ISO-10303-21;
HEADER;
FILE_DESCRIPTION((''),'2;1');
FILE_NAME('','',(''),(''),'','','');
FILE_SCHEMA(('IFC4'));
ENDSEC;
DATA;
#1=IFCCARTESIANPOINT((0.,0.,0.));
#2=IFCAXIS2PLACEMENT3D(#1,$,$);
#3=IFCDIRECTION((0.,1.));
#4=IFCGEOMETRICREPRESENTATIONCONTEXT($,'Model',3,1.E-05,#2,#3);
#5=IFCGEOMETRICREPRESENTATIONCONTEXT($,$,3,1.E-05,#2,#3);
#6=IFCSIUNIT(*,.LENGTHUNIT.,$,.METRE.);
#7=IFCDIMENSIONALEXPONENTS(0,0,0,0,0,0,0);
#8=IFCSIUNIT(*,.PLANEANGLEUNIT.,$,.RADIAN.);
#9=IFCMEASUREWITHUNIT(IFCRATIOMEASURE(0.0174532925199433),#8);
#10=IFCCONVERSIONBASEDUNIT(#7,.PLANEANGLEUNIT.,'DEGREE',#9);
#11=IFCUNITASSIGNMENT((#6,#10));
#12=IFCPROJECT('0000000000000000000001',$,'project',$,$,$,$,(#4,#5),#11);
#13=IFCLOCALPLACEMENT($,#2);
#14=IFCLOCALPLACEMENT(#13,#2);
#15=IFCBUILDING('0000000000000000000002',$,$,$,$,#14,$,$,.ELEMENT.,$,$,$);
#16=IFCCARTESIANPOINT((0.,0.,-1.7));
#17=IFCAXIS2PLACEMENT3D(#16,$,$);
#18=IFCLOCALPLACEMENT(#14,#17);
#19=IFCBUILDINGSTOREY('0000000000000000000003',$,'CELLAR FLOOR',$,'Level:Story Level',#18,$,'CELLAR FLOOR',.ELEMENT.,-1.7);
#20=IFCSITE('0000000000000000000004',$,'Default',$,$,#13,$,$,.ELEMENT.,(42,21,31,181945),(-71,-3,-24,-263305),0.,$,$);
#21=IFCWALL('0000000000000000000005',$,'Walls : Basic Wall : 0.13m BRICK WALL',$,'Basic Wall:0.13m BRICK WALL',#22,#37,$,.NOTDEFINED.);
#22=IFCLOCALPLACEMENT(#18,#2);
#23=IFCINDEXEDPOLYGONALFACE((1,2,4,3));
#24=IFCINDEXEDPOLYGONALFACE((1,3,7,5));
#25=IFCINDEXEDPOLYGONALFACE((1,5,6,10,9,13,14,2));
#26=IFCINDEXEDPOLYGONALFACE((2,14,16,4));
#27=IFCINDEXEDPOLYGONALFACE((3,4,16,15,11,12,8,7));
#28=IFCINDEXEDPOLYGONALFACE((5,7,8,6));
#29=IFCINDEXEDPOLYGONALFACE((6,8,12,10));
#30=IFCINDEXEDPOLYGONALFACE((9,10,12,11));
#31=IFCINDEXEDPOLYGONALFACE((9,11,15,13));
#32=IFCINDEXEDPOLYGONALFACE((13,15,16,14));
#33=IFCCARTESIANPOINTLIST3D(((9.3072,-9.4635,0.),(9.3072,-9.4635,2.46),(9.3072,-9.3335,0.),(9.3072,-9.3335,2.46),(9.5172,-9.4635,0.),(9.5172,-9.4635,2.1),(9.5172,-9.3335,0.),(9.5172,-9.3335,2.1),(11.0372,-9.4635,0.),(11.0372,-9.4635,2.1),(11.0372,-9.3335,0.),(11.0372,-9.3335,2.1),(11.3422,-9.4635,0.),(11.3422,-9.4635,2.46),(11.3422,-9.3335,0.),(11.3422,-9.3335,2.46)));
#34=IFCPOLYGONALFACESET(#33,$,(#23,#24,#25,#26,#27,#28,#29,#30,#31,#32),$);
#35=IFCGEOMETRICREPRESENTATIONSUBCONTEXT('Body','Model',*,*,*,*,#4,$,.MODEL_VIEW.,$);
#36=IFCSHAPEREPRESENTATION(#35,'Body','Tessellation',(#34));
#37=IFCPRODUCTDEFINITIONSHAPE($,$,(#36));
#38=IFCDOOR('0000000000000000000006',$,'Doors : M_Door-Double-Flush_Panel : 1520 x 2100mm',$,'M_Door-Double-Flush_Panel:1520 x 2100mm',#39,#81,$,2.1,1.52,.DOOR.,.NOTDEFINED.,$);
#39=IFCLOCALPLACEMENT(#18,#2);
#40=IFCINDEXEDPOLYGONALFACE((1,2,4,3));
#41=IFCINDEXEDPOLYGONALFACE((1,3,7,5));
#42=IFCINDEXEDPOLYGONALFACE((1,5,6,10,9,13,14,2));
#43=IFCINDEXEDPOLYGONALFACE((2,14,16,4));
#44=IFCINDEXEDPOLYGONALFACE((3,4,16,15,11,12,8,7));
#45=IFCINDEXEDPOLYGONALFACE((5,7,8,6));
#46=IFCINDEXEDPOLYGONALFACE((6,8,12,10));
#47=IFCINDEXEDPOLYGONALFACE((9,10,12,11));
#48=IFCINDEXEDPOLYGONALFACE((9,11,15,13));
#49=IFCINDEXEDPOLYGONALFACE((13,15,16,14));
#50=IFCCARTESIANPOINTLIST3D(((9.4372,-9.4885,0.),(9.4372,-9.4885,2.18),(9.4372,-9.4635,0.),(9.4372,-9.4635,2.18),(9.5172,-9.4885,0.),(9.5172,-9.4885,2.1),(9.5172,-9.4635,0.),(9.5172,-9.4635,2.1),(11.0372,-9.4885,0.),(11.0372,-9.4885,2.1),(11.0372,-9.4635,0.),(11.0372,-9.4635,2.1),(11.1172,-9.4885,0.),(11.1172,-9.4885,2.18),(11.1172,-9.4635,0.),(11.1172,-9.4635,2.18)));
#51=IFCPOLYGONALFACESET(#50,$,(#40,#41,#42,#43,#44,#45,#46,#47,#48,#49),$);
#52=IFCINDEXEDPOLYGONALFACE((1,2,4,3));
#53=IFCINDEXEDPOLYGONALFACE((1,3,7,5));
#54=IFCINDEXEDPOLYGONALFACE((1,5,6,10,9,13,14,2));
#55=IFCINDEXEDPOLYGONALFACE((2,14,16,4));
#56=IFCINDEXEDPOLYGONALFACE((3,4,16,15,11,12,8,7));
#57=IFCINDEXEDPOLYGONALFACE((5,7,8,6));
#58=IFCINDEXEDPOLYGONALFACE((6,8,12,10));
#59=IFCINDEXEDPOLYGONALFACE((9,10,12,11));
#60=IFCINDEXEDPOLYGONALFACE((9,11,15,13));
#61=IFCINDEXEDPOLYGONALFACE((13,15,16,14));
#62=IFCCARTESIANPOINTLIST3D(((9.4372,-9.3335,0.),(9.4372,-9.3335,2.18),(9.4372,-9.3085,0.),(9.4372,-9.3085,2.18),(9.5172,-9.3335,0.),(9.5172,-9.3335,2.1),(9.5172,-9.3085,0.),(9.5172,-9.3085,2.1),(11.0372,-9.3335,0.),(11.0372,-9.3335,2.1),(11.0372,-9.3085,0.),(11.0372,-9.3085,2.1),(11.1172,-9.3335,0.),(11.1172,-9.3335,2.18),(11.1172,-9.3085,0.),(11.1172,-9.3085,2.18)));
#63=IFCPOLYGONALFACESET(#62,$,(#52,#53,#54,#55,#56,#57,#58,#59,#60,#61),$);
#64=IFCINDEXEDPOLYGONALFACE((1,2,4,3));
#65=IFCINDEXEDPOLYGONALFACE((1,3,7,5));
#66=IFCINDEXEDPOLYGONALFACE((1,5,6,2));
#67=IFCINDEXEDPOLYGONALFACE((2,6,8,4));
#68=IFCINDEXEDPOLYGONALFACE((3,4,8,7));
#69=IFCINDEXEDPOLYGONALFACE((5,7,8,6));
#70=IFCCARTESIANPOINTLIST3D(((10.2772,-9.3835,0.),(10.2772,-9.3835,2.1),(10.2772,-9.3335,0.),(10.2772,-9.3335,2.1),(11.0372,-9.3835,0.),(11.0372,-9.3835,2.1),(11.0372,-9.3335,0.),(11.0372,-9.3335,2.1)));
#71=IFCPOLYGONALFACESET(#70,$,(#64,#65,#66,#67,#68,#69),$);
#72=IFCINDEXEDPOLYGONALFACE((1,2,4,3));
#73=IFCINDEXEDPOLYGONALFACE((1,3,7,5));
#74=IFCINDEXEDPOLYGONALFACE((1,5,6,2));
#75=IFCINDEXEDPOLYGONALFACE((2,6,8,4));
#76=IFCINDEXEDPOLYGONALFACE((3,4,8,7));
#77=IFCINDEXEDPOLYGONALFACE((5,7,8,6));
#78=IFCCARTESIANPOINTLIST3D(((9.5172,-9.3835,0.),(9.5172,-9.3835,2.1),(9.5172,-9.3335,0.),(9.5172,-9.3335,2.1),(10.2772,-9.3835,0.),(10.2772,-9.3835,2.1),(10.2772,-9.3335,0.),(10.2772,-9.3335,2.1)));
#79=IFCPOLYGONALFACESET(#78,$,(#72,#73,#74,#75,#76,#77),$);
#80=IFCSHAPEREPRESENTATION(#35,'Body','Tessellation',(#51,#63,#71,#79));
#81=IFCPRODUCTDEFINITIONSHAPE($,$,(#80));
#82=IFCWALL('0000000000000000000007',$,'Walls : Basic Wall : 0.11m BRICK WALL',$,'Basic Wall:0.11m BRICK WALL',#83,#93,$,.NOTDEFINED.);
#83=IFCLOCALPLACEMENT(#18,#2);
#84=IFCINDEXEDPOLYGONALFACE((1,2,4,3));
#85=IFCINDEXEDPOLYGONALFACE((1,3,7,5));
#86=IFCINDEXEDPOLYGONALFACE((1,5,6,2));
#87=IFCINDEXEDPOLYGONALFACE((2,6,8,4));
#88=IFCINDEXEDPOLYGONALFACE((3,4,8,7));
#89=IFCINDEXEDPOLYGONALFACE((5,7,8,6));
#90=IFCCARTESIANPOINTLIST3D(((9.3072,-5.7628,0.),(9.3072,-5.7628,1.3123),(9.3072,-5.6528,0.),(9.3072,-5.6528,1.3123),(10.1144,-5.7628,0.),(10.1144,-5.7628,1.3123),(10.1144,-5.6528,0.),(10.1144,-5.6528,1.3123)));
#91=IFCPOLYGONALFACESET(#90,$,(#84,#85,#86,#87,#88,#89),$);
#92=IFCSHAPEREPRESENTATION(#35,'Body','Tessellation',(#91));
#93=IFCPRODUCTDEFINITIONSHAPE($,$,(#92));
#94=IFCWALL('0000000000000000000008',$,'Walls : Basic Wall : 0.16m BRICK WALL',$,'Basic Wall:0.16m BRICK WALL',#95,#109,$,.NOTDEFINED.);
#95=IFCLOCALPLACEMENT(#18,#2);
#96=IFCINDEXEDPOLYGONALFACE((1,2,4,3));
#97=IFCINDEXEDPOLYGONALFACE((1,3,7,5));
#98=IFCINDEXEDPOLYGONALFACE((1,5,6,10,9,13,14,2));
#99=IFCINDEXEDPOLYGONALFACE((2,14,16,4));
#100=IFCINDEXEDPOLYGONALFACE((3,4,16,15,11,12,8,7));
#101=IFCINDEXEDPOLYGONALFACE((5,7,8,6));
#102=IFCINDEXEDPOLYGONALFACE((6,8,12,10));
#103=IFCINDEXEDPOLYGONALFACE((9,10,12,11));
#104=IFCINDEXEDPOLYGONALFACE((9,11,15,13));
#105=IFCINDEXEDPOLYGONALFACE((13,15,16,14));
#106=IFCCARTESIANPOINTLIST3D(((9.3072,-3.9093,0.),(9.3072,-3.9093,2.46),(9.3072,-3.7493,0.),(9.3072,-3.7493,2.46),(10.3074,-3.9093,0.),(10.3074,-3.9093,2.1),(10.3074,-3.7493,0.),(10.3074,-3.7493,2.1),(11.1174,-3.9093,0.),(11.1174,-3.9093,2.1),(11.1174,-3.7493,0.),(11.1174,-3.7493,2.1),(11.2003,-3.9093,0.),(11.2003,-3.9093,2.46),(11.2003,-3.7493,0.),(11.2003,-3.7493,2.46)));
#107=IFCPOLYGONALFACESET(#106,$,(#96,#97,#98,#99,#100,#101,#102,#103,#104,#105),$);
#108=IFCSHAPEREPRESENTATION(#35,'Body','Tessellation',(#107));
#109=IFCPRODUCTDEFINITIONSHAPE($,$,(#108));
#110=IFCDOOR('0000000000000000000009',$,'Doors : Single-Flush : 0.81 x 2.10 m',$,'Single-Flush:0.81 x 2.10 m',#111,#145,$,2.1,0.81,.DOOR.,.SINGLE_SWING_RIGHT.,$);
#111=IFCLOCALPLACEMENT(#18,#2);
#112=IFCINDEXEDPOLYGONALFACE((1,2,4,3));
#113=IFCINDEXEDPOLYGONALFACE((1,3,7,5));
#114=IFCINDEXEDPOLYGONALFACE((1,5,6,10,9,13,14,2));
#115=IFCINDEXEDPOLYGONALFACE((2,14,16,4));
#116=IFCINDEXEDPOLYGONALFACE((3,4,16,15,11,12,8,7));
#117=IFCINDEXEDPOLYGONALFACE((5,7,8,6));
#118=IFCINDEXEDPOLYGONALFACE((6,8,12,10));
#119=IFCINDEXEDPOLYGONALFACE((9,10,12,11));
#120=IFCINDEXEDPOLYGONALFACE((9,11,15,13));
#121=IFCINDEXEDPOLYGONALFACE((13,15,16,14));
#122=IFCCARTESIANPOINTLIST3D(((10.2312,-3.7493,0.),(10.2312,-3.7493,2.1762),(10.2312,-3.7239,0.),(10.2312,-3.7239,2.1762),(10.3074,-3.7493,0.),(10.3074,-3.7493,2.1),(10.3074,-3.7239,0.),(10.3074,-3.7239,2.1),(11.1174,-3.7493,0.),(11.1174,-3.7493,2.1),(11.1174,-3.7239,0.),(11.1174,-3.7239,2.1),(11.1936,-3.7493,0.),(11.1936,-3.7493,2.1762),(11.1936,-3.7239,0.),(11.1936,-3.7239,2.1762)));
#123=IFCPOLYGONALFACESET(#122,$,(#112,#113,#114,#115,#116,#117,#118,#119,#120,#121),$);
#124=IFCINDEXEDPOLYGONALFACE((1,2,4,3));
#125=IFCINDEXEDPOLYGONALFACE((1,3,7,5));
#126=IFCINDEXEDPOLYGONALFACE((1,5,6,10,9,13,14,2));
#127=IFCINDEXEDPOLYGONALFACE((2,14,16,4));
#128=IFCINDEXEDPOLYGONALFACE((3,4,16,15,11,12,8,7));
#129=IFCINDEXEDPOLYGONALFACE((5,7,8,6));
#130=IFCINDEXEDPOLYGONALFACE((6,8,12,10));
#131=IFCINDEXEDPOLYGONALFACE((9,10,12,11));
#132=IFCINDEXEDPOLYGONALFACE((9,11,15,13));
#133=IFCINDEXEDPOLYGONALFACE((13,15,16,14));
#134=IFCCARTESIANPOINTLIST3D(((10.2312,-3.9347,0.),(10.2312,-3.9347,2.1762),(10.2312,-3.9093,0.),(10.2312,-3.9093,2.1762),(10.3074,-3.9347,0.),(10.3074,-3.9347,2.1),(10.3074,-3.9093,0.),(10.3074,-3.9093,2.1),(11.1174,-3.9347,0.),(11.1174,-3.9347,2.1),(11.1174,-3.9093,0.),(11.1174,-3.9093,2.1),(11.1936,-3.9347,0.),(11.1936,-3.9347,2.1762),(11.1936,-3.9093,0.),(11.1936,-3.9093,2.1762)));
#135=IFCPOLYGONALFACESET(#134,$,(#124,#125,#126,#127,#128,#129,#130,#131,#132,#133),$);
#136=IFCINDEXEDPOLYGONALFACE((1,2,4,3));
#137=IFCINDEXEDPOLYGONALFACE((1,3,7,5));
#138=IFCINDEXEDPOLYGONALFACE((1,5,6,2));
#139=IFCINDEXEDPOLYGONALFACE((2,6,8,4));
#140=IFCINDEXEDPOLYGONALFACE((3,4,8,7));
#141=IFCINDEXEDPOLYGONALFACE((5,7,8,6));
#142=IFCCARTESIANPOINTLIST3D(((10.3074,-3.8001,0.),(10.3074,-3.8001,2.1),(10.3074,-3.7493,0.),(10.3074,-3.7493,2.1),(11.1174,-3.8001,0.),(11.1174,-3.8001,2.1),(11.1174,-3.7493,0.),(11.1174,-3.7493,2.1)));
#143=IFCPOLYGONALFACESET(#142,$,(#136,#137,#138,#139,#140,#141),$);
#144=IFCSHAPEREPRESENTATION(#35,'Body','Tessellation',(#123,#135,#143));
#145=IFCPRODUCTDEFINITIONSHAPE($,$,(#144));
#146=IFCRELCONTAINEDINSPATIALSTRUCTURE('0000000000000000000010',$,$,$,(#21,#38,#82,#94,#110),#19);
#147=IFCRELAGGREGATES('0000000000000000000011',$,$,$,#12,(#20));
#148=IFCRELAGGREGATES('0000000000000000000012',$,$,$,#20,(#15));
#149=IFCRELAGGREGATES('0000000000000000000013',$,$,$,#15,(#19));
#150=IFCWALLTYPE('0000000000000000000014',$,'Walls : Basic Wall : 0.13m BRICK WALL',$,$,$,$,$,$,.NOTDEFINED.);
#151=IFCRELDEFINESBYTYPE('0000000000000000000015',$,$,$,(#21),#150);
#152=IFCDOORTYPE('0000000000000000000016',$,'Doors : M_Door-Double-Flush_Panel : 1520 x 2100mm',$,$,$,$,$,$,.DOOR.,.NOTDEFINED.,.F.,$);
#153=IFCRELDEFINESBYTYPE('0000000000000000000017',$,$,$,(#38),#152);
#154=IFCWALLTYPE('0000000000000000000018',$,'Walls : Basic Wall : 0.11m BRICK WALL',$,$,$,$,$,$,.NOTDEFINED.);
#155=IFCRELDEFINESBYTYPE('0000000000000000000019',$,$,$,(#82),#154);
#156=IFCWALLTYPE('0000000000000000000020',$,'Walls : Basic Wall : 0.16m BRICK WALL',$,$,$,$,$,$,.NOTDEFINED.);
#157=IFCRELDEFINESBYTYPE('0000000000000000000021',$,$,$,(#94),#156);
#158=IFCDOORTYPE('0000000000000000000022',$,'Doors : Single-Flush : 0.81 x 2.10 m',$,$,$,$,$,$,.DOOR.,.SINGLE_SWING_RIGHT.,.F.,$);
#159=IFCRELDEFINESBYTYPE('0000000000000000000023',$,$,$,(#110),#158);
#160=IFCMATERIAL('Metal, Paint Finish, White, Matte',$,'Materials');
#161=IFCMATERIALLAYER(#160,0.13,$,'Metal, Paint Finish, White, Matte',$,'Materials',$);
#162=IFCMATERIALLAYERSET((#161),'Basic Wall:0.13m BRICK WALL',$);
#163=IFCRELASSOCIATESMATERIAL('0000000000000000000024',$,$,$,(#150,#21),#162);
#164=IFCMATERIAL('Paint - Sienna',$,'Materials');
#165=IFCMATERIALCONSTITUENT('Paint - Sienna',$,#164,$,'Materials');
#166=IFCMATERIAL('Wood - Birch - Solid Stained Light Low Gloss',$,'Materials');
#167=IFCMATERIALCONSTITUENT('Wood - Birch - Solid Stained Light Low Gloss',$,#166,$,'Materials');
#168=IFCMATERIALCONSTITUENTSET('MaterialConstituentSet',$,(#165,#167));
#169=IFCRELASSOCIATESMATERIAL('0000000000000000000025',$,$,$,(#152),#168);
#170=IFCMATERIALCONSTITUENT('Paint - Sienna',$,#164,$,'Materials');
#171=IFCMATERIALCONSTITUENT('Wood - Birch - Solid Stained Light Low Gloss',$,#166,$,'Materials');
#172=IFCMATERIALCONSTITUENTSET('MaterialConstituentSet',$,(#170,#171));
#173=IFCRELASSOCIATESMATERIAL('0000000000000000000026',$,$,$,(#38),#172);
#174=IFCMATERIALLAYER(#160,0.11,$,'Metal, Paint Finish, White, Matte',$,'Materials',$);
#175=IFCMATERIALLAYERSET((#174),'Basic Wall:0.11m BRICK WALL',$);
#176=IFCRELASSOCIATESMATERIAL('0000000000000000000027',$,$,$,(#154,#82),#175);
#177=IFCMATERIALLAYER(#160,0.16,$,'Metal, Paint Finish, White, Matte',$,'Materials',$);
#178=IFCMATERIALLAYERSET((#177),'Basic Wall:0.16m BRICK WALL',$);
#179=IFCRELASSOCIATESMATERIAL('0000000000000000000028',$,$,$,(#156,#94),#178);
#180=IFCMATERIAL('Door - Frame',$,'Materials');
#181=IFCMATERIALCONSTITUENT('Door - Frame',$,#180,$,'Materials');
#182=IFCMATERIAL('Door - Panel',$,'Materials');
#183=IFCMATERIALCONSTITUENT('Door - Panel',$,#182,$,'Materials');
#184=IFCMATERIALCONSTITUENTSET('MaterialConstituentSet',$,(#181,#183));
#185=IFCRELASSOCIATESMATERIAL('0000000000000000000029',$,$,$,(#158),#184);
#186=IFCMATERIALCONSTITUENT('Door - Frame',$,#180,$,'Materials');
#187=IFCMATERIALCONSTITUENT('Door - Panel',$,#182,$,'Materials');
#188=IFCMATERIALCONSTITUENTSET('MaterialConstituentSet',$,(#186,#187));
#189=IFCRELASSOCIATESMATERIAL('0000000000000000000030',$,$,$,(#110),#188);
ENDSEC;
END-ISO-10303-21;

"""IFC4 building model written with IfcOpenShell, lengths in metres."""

from ifc_helpers import new_model, entity, si_unit, converted_unit, direction, frame, frame_2d, origin, origin_2d_with_axis, place, context, subcontext, project, spatial, polyline, rectangle, outline, extrude, source, transform, mapped, material, layer, layer_set, layer_usage, constituent, constituent_set, type_object, type_shapes, element, fill, save


model = new_model("IFC4")

# Units and contexts
model_context = context("Model", 3, precision=1e-05, world=origin(), true_north=direction((0.0, 1.0)))
context_of_model = context(None, 3, precision=1e-05, world=origin(), true_north=direction((0.0, 1.0)))
body_context = subcontext(model_context, "Body", "Model", "MODEL_VIEW")
ifc_project = project(units=[si_unit("LENGTHUNIT", "METRE"), converted_unit("PLANEANGLEUNIT", "DEGREE", entity("IfcRatioMeasure", 0.0174532925199433), si_unit("PLANEANGLEUNIT", "RADIAN"), dimensions=[0, 0, 0, 0, 0, 0, 0])], contexts=[model_context, context_of_model])

# Site, building, storey
site_placement = place(None, origin())
site = spatial("IfcSite", under=ifc_project, at=site_placement, Name="Default", CompositionType="ELEMENT", RefLatitude=(42, 21, 31, 181945), RefLongitude=(-71, -3, -24, -263305), RefElevation=0.0)
building_placement = place(site_placement, origin())
building = spatial("IfcBuilding", under=site, at=building_placement, CompositionType="ELEMENT")
storey_placement = place(building_placement, frame((0.0, 0.0, -1.7)))
storey = spatial("IfcBuildingStorey", under=building, at=storey_placement, Name="CELLAR FLOOR", ObjectType="Level:Story Level", LongName="CELLAR FLOOR", CompositionType="ELEMENT", Elevation=-1.7)

# Wall, opening, door
ifc_material_1 = material(Name="Metal, Paint Finish, White, Matte", Category="Materials")
ifc_layer_1 = layer(ifc_material_1, 0.13, Name="Metal, Paint Finish, White, Matte", Category="Materials")
ifc_layer_set_1 = layer_set([ifc_layer_1], Name="Basic Wall:0.13m BRICK WALL")
ifc_layer_usage_1 = layer_usage(ifc_layer_set_1, "AXIS2", "NEGATIVE", 0.065)
wall_type_1 = type_object("IfcWallType", Name="Walls : Basic Wall : 0.13m BRICK WALL", PredefinedType="NOTDEFINED", material=ifc_layer_set_1)
wall_1_placement = place(storey_placement, frame((9.3072, -9.3985, 0.0)))
wall_1 = element("IfcWall", 1, at=wall_1_placement, inside=storey, type_object=wall_type_1, material=ifc_layer_usage_1, Name="Walls : Basic Wall : 0.13m BRICK WALL", ObjectType="Basic Wall:0.13m BRICK WALL", PredefinedType="NOTDEFINED", context=body_context, shape_type="SweptSolid", body=[
    extrude(rectangle(XDim=2.0349, YDim=0.13, at=frame_2d((1.0175, 0.0), x_axis=(-1.0, 0.0))), origin(), (0.0, 0.0, 1.0), 2.46),
])
opening_1_placement = place(wall_1_placement, frame((0.2099, -0.065, 0.0)))
opening_1 = element("IfcOpeningElement", 2, at=opening_1_placement, cuts=wall_1, ObjectType="Opening", PredefinedType="OPENING", context=body_context, shape_type="SweptSolid", body=[
    extrude(rectangle(XDim=2.1, YDim=1.52, at=frame_2d((1.05, 0.76), x_axis=(1.0, 0.0))), frame((0.0, 0.0, 0.0), z_axis=(0.0, 1.0, 0.0), x_axis=(0.0, 0.0, 1.0)), (0.0, 0.0, 1.0), 0.13),
])
ifc_material_2 = material(Name="Paint - Sienna", Category="Materials")
ifc_constituent_1 = constituent(ifc_material_2, Name="Paint - Sienna", Category="Materials")
ifc_material_3 = material(Name="Wood - Birch - Solid Stained Light Low Gloss", Category="Materials")
ifc_constituent_2 = constituent(ifc_material_3, Name="Wood - Birch - Solid Stained Light Low Gloss", Category="Materials")
ifc_constituent_set_1 = constituent_set(constituents=[ifc_constituent_1, ifc_constituent_2], Name="MaterialConstituentSet")
ifc_constituent_3 = constituent(ifc_material_2, Name="Paint - Sienna", Category="Materials")
ifc_constituent_4 = constituent(ifc_material_3, Name="Wood - Birch - Solid Stained Light Low Gloss", Category="Materials")
ifc_constituent_set_2 = constituent_set(constituents=[ifc_constituent_3, ifc_constituent_4], Name="MaterialConstituentSet")
door_type_1 = type_object("IfcDoorType", Name="Doors : M_Door-Double-Flush_Panel : 1520 x 2100mm", OperationType="NOTDEFINED", ParameterTakesPrecedence=False, PredefinedType="DOOR", material=ifc_constituent_set_2)
shared_shape_1 = source(origin(), body_context, "Body", "SweptSolid", [
    extrude(outline(polyline([(-1.03, 0.76), (1.07, 0.76), (1.07, 0.84), (-1.11, 0.84), (-1.11, -0.84), (1.07, -0.84), (1.07, -0.76), (-1.03, -0.76), (-1.03, 0.76)])), frame((0.76, -0.025, 1.07), z_axis=(0.0, 1.0, 0.0), x_axis=(0.0, 0.0, -1.0)), (0.0, 0.0, 1.0), 0.025),
    extrude(outline(polyline([(-1.03, 0.76), (1.07, 0.76), (1.07, 0.84), (-1.11, 0.84), (-1.11, -0.84), (1.07, -0.84), (1.07, -0.76), (-1.03, -0.76), (-1.03, 0.76)])), frame((0.76, 0.13, 1.07), z_axis=(0.0, 1.0, 0.0), x_axis=(0.0, 0.0, -1.0)), (0.0, 0.0, 1.0), 0.025),
    extrude(rectangle(XDim=0.05, YDim=0.76, at=origin_2d_with_axis()), frame((1.14, 0.105, 0.0), z_axis=(0.0, 0.0, 1.0), x_axis=(0.0, -1.0, 0.0)), (0.0, 0.0, 1.0), 2.1),
    extrude(rectangle(XDim=0.05, YDim=0.76, at=origin_2d_with_axis()), frame((0.38, 0.105, 0.0), z_axis=(0.0, 0.0, 1.0), x_axis=(0.0, -1.0, 0.0)), (0.0, 0.0, 1.0), 2.1),
])
type_shapes(door_type_1, [shared_shape_1])
door_1_placement = place(opening_1_placement, origin())
door_1 = element("IfcDoor", 3, at=door_1_placement, inside=storey, type_object=door_type_1, material=ifc_constituent_set_1, Name="Doors : M_Door-Double-Flush_Panel : 1520 x 2100mm", ObjectType="M_Door-Double-Flush_Panel:1520 x 2100mm", OperationType="NOTDEFINED", OverallHeight=2.1, OverallWidth=1.52, PredefinedType="DOOR", context=body_context, shape_type="MappedRepresentation", body=[
    mapped(shared_shape_1, transform((0.0, 0.0, 0.0), scale=1.0)),
])
fill(opening_1, door_1)

# Wall
ifc_layer_2 = layer(ifc_material_1, 0.11, Name="Metal, Paint Finish, White, Matte", Category="Materials")
ifc_layer_set_2 = layer_set([ifc_layer_2], Name="Basic Wall:0.11m BRICK WALL")
ifc_layer_usage_2 = layer_usage(ifc_layer_set_2, "AXIS2", "NEGATIVE", 0.055)
wall_type_2 = type_object("IfcWallType", Name="Walls : Basic Wall : 0.11m BRICK WALL", PredefinedType="NOTDEFINED", material=ifc_layer_set_2)
wall_2_placement = place(storey_placement, frame((10.1144, -5.7078, 0.0), z_axis=(0.0, 0.0, 1.0), x_axis=(-1.0, 0.0, 0.0)))
element("IfcWall", 4, at=wall_2_placement, inside=storey, type_object=wall_type_2, material=ifc_layer_usage_2, Name="Walls : Basic Wall : 0.11m BRICK WALL", ObjectType="Basic Wall:0.11m BRICK WALL", PredefinedType="NOTDEFINED", context=body_context, shape_type="SweptSolid", body=[
    extrude(rectangle(XDim=0.8072, YDim=0.11, at=frame_2d((0.4036, 0.0), x_axis=(-1.0, 0.0))), origin(), (0.0, 0.0, 1.0), 1.3123),
])

# Wall, opening, door
ifc_layer_3 = layer(ifc_material_1, 0.16, Name="Metal, Paint Finish, White, Matte", Category="Materials")
ifc_layer_set_3 = layer_set([ifc_layer_3], Name="Basic Wall:0.16m BRICK WALL")
ifc_layer_usage_3 = layer_usage(ifc_layer_set_3, "AXIS2", "NEGATIVE", 0.08)
wall_type_3 = type_object("IfcWallType", Name="Walls : Basic Wall : 0.16m BRICK WALL", PredefinedType="NOTDEFINED", material=ifc_layer_set_3)
wall_3_placement = place(storey_placement, frame((9.3072, -3.8293, 0.0)))
wall_3 = element("IfcWall", 5, at=wall_3_placement, inside=storey, type_object=wall_type_3, material=ifc_layer_usage_3, Name="Walls : Basic Wall : 0.16m BRICK WALL", ObjectType="Basic Wall:0.16m BRICK WALL", PredefinedType="NOTDEFINED", context=body_context, shape_type="SweptSolid", body=[
    extrude(rectangle(XDim=1.8931, YDim=0.16, at=frame_2d((0.9466, 0.0), x_axis=(-1.0, 0.0))), origin(), (0.0, 0.0, 1.0), 2.46),
])
opening_2_placement = place(wall_3_placement, frame((1.0001, -0.08, 0.0)))
opening_2 = element("IfcOpeningElement", 6, at=opening_2_placement, cuts=wall_3, ObjectType="Opening", PredefinedType="OPENING", context=body_context, shape_type="SweptSolid", body=[
    extrude(rectangle(XDim=0.81, YDim=2.1, at=frame_2d((1.05, 0.405), x_axis=(0.0, 1.0))), frame((0.0, 0.0, 0.0), z_axis=(0.0, 1.0, 0.0), x_axis=(0.0, 0.0, 1.0)), (0.0, 0.0, 1.0), 0.16),
])
ifc_material_4 = material(Name="Door - Frame", Category="Materials")
ifc_constituent_5 = constituent(ifc_material_4, Name="Door - Frame", Category="Materials")
ifc_material_5 = material(Name="Door - Panel", Category="Materials")
ifc_constituent_6 = constituent(ifc_material_5, Name="Door - Panel", Category="Materials")
ifc_constituent_set_3 = constituent_set(constituents=[ifc_constituent_5, ifc_constituent_6], Name="MaterialConstituentSet")
ifc_constituent_7 = constituent(ifc_material_4, Name="Door - Frame", Category="Materials")
ifc_constituent_8 = constituent(ifc_material_5, Name="Door - Panel", Category="Materials")
ifc_constituent_set_4 = constituent_set(constituents=[ifc_constituent_7, ifc_constituent_8], Name="MaterialConstituentSet")
door_type_2 = type_object("IfcDoorType", Name="Doors : Single-Flush : 0.81 x 2.10 m", OperationType="SINGLE_SWING_RIGHT", ParameterTakesPrecedence=False, PredefinedType="DOOR", material=ifc_constituent_set_4)
shared_shape_2 = source(origin(), body_context, "Body", "SweptSolid", [
    extrude(outline(polyline([(-0.4812, -1.1072), (0.4812, -1.1072), (0.4812, 1.0691), (0.405, 1.0691), (0.405, -1.031), (-0.405, -1.031), (-0.405, 1.0691), (-0.4812, 1.0691), (-0.4812, -1.1072)])), frame((0.405, 0.16, 1.0691), z_axis=(0.0, 1.0, 0.0), x_axis=(1.0, 0.0, 0.0)), (0.0, 0.0, 1.0), 0.0254),
    extrude(outline(polyline([(-1.1072, -0.4812), (1.0691, -0.4812), (1.0691, -0.405), (-1.031, -0.405), (-1.031, 0.405), (1.0691, 0.405), (1.0691, 0.4812), (-1.1072, 0.4812), (-1.1072, -0.4812)])), frame((0.405, -0.0254, 1.0691), z_axis=(0.0, 1.0, 0.0), x_axis=(0.0, 0.0, -1.0)), (0.0, 0.0, 1.0), 0.0254),
    extrude(rectangle(XDim=0.0508, YDim=0.81, at=frame_2d((0.0, 0.0), x_axis=(1.0, 0.0))), frame((0.405, 0.1346, 0.0), z_axis=(0.0, 0.0, 1.0), x_axis=(0.0, 1.0, 0.0)), (0.0, 0.0, 1.0), 2.1),
])
type_shapes(door_type_2, [shared_shape_2])
door_2_placement = place(opening_2_placement, origin())
door_2 = element("IfcDoor", 7, at=door_2_placement, inside=storey, type_object=door_type_2, material=ifc_constituent_set_3, Name="Doors : Single-Flush : 0.81 x 2.10 m", ObjectType="Single-Flush:0.81 x 2.10 m", OperationType="SINGLE_SWING_RIGHT", OverallHeight=2.1, OverallWidth=0.81, PredefinedType="DOOR", context=body_context, shape_type="MappedRepresentation", body=[
    mapped(shared_shape_2, transform((0.0, 0.0, 0.0), scale=1.0)),
])
fill(opening_2, door_2)

save(model, "model.ifc")
